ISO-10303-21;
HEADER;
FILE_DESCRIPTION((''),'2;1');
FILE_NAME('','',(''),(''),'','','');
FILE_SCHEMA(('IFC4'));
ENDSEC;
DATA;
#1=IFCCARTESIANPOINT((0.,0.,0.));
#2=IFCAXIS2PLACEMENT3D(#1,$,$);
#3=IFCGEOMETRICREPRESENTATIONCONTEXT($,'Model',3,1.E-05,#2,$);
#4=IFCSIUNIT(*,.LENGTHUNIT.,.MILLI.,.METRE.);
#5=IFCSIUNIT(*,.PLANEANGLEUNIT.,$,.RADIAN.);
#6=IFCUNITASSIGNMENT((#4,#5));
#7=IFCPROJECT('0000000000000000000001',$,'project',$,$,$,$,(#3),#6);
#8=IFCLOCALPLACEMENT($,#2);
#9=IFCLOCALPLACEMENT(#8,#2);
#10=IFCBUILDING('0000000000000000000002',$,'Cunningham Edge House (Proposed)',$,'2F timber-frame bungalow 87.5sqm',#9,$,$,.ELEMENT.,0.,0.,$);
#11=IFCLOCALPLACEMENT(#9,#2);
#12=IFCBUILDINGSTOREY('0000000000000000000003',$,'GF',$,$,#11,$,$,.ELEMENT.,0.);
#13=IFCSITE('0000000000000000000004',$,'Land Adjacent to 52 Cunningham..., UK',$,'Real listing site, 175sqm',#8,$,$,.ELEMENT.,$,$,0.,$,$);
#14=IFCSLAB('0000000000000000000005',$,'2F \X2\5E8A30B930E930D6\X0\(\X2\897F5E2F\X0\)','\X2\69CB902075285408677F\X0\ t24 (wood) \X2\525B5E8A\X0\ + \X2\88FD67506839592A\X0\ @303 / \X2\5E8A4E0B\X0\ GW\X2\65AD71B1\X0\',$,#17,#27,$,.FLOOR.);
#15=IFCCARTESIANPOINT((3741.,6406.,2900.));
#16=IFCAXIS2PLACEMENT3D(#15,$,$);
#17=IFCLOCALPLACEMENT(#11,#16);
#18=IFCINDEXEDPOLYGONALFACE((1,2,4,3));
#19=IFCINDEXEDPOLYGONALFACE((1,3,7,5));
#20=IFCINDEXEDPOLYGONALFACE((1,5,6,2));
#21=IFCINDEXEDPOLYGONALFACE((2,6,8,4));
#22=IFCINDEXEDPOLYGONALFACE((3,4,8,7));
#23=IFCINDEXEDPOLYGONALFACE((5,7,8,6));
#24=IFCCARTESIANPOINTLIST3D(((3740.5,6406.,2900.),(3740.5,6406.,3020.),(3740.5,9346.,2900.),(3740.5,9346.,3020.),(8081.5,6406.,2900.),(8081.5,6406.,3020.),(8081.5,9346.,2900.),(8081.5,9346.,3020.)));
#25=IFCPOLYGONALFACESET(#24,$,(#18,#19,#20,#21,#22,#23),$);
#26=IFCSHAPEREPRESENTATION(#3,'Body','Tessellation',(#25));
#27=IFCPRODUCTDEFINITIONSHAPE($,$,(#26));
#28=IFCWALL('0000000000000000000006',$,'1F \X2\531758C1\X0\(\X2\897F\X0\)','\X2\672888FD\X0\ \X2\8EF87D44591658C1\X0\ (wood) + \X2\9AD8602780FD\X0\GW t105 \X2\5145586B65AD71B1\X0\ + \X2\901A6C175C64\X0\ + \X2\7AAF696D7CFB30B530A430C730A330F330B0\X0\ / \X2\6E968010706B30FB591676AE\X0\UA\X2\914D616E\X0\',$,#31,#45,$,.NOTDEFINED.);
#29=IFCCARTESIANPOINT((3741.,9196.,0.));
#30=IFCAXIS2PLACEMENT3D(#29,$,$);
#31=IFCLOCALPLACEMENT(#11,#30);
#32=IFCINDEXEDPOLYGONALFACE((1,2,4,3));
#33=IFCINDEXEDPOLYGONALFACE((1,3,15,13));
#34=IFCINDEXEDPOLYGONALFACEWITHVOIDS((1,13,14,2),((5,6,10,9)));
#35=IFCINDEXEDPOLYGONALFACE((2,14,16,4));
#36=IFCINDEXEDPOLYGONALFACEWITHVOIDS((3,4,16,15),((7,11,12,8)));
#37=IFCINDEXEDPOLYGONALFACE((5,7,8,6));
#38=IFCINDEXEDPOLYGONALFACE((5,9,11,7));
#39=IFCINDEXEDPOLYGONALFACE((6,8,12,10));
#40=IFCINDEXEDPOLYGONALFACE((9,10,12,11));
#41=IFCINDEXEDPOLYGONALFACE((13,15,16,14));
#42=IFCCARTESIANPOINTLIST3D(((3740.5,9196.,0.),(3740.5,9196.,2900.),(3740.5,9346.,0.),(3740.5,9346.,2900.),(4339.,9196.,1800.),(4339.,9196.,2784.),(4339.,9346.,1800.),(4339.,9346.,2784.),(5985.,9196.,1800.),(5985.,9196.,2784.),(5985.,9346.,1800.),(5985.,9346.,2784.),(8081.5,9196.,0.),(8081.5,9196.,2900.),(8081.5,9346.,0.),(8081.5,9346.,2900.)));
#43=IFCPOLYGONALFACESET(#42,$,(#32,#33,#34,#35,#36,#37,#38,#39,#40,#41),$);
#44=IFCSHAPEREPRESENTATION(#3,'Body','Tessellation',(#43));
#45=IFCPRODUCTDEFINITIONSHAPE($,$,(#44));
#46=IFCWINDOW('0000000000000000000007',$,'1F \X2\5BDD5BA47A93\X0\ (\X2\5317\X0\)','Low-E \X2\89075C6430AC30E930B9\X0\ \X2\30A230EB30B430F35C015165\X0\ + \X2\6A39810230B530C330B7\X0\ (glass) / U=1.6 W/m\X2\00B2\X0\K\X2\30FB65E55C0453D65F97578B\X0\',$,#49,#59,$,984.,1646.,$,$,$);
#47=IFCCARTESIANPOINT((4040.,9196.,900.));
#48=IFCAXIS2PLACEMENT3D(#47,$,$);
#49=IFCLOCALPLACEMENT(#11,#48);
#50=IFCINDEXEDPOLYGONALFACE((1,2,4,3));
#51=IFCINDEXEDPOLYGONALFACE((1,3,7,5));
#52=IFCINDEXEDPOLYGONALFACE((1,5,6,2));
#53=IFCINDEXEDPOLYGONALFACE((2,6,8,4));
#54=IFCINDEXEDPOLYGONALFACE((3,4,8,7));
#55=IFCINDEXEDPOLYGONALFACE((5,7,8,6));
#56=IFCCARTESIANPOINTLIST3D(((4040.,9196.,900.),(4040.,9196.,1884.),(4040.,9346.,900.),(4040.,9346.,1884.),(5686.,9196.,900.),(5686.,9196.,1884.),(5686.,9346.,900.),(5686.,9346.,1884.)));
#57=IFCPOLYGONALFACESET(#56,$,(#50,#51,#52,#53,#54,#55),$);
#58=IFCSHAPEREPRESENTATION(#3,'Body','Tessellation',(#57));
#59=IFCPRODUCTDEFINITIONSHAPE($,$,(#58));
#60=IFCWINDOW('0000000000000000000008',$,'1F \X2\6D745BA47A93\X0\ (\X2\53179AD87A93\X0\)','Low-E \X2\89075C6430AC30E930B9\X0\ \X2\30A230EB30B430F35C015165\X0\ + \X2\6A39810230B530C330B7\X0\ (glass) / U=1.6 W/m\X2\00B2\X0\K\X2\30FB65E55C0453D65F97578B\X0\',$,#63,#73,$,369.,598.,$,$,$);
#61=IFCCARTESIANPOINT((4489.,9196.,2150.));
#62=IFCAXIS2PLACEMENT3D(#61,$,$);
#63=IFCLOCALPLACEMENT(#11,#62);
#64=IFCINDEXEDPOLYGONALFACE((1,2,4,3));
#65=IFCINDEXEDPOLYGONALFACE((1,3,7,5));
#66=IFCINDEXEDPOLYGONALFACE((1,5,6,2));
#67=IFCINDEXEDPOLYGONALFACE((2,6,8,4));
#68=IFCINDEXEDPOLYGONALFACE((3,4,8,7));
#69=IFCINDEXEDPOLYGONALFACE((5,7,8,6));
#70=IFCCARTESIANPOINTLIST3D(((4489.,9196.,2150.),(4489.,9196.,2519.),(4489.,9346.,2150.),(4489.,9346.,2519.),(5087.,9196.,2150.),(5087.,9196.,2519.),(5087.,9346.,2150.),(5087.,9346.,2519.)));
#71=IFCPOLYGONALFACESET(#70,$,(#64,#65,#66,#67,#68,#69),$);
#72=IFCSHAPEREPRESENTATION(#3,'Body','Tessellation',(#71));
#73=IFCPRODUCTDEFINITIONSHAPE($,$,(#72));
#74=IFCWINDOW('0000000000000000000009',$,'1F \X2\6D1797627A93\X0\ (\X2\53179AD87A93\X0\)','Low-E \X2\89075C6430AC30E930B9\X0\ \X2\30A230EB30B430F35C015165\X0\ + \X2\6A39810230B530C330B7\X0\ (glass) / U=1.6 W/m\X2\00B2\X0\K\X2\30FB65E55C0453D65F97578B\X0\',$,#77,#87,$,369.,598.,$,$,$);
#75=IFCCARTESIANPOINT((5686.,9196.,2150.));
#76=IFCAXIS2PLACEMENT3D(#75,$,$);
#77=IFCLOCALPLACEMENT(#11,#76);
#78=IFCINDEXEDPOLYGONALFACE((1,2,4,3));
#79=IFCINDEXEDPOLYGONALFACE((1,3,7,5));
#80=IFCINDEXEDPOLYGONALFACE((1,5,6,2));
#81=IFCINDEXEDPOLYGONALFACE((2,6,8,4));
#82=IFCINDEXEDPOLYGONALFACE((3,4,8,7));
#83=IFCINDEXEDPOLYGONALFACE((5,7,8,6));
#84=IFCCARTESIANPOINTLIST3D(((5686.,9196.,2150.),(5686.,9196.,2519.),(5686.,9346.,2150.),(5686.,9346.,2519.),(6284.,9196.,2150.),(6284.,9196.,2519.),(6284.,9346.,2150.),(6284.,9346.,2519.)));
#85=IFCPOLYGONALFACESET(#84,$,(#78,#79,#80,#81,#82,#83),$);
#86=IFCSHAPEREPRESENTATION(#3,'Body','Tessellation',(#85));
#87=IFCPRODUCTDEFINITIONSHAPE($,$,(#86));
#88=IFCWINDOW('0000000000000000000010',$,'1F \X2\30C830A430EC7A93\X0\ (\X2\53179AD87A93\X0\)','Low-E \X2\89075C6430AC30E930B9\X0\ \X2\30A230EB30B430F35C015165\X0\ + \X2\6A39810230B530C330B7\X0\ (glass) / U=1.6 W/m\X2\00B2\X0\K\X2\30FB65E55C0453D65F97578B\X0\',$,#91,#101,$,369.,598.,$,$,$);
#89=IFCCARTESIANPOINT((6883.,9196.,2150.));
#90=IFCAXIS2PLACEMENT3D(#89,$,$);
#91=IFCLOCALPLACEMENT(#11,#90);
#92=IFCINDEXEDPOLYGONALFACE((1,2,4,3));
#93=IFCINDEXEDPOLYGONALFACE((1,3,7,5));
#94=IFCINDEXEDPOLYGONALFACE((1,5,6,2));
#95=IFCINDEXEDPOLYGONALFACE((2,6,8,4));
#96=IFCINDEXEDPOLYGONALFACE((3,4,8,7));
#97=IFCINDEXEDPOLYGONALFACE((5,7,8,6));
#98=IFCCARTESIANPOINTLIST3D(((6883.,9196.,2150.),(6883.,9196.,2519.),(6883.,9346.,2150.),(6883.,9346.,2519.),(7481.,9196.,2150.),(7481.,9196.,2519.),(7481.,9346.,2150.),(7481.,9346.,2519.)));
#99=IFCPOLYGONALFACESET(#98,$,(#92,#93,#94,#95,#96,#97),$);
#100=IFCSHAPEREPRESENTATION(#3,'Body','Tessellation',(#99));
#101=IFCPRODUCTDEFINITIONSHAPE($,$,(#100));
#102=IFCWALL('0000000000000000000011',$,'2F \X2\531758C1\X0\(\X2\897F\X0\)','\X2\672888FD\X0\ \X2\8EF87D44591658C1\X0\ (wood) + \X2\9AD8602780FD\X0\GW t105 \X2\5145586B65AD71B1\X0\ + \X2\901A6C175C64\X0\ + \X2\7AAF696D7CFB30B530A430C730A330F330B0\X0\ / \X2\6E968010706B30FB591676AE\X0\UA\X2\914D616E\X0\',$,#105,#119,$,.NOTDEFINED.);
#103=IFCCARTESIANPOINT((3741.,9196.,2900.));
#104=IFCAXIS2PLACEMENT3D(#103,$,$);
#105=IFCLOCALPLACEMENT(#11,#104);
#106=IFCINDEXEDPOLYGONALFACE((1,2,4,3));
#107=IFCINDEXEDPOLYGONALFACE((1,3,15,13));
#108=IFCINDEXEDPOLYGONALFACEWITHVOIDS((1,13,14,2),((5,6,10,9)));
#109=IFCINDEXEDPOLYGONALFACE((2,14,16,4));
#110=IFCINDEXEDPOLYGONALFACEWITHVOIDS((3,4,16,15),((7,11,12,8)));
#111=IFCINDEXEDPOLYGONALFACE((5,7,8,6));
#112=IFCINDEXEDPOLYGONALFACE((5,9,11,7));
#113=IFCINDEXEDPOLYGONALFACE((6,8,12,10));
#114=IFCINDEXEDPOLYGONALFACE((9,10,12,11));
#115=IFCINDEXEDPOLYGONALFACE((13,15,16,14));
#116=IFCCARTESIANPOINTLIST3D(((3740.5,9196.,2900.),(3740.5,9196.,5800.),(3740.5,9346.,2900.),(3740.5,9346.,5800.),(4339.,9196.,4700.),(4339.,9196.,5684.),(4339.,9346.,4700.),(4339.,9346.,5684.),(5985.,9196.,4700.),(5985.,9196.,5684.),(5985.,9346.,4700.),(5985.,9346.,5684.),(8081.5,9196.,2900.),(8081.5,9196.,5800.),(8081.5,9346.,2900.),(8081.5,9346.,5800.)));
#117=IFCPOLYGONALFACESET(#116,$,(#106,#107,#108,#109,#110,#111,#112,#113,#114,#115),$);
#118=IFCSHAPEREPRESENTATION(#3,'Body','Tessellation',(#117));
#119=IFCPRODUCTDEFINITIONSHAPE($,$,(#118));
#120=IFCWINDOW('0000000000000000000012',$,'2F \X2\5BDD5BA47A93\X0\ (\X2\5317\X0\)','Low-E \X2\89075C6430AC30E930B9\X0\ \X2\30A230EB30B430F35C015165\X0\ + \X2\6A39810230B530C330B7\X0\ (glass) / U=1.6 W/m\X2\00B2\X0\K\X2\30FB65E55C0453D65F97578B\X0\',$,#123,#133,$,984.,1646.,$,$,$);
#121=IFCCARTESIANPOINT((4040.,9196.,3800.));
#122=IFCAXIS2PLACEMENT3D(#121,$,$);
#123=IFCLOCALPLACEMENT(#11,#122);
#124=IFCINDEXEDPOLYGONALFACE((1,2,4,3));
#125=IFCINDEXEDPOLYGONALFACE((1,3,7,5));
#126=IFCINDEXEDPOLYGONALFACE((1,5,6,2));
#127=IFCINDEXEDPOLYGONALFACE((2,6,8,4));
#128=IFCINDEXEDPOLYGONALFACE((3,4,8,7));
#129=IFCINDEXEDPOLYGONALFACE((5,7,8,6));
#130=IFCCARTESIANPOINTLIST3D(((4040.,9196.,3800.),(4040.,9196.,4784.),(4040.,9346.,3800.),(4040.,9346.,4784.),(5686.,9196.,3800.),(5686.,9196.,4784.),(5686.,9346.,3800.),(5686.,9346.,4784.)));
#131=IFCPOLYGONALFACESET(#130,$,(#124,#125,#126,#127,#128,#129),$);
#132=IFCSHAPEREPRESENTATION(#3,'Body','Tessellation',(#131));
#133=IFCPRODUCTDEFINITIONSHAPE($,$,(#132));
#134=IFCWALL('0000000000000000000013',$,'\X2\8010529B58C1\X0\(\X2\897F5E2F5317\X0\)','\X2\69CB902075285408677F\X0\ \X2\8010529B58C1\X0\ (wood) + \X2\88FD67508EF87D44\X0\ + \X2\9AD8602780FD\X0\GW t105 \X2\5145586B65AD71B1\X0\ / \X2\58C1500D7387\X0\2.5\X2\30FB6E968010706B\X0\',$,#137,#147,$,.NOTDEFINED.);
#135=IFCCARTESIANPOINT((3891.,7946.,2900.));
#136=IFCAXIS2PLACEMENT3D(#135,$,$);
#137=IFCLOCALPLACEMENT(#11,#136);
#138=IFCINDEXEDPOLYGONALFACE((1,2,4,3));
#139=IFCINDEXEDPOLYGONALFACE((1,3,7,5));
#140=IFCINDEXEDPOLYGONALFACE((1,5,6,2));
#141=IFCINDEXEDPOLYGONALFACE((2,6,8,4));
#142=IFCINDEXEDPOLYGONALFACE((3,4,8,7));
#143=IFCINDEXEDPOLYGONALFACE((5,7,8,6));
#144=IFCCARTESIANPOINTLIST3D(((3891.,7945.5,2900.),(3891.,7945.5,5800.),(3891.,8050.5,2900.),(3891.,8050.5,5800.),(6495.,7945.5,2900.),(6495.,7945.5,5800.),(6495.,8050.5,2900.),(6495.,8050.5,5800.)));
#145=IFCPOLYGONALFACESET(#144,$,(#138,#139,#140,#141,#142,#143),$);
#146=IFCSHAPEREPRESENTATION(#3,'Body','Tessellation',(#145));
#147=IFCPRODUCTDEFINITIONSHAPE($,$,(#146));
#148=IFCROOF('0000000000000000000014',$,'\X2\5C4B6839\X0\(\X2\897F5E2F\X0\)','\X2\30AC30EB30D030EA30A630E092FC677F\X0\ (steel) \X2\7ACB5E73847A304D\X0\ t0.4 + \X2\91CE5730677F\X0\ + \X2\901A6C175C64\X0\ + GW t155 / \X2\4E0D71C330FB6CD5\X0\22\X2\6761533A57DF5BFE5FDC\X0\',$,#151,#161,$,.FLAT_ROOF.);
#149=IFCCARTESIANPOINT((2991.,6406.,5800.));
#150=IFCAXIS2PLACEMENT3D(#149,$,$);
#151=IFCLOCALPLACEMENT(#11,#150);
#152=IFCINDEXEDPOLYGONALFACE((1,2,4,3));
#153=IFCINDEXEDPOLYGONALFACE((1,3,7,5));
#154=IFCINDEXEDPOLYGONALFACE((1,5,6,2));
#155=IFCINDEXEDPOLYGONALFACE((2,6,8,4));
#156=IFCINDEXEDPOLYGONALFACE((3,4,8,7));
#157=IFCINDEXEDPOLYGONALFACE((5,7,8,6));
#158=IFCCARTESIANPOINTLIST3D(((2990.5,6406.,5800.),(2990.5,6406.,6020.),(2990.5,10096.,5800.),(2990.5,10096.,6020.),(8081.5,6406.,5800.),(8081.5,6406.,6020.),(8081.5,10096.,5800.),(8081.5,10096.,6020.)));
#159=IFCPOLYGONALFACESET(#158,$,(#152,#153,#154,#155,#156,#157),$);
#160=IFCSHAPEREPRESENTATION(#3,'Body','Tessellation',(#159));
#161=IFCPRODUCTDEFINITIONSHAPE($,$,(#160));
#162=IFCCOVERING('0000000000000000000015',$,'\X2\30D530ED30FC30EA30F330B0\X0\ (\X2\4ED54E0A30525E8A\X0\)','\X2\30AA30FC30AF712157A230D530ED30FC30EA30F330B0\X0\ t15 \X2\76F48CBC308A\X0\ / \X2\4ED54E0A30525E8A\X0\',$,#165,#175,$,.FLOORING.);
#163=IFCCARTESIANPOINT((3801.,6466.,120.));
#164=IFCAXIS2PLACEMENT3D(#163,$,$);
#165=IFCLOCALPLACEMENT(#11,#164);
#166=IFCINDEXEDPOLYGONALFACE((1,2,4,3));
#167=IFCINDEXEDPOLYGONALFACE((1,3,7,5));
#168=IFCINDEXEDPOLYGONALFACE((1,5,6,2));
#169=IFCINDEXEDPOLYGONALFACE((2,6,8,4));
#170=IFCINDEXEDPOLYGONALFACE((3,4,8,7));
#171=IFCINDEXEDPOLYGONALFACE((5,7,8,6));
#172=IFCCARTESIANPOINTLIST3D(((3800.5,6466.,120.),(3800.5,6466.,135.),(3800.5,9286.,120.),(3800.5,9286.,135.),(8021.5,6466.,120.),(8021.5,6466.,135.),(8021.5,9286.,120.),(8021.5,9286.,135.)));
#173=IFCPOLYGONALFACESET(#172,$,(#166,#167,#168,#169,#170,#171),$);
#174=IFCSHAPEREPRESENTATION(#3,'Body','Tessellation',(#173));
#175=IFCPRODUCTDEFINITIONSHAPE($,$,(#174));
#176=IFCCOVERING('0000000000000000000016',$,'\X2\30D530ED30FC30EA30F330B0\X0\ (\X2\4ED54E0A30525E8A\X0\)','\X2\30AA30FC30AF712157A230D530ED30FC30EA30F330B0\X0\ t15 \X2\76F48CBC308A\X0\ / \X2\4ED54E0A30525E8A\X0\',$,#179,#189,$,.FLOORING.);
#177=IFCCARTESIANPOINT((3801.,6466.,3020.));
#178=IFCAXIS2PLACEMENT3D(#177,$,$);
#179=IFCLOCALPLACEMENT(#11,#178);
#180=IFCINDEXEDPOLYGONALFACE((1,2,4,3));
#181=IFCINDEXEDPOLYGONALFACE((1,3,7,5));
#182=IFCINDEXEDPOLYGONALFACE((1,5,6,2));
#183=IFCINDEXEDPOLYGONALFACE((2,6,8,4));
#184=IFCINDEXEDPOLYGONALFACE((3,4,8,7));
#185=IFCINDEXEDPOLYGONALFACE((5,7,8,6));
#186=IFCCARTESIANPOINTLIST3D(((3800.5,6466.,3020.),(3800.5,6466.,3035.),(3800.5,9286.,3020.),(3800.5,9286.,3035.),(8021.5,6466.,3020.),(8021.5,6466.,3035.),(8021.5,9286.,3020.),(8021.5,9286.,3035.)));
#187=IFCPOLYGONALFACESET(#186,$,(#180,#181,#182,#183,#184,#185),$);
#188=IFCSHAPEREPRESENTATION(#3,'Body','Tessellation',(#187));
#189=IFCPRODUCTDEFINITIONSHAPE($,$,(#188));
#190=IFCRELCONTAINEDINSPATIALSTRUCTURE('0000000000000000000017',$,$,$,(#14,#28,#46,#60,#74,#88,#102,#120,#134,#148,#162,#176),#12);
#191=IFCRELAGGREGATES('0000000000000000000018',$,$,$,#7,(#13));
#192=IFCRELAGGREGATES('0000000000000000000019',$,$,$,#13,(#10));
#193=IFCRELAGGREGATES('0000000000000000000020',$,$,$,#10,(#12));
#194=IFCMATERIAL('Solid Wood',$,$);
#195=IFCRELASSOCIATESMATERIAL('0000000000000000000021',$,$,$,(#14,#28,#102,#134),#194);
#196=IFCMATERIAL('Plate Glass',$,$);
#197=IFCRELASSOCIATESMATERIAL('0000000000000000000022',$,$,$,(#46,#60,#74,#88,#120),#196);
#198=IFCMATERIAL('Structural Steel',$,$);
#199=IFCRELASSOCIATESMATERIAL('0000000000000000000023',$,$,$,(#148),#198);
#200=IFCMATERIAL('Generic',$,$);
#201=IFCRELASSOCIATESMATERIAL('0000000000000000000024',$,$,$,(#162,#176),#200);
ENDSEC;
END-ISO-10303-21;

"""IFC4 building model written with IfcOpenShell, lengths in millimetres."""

from ifc_helpers import new_model, si_unit, frame, frame_2d, origin, place, context, project, spatial, rectangle, extrude, material, element, fill, save


model = new_model("IFC4")

# Units and contexts
model_context = context("Model", 3, precision=1e-05, world=origin())
ifc_project = project(units=[si_unit("LENGTHUNIT", "METRE", prefix="MILLI"), si_unit("PLANEANGLEUNIT", "RADIAN")], contexts=[model_context])

# Site, building, storey
site_placement = place(None, origin())
site = spatial("IfcSite", under=ifc_project, at=site_placement, Name="Land Adjacent to 52 Cunningham..., UK", ObjectType="Real listing site, 175sqm", CompositionType="ELEMENT", RefElevation=0.0)
building_placement = place(site_placement, origin())
building = spatial("IfcBuilding", under=site, at=building_placement, Name="Cunningham Edge House (Proposed)", ObjectType="2F timber-frame bungalow 87.5sqm", CompositionType="ELEMENT", ElevationOfRefHeight=0.0, ElevationOfTerrain=0.0)
storey_placement = place(building_placement, origin())
storey = spatial("IfcBuildingStorey", under=building, at=storey_placement, Name="GF", CompositionType="ELEMENT", Elevation=0.0)

# Slab
ifc_material_1 = material(Name="Solid Wood")
slab_1_placement = place(storey_placement, frame((3741.0, 6406.0, 2900.0)))
element("IfcSlab", 1, at=slab_1_placement, inside=storey, material=ifc_material_1, Name="2F 床スラブ(西帯)", Description="構造用合板 t24 (wood) 剛床 + 製材根太 @303 / 床下 GW断熱", PredefinedType="FLOOR", context=model_context, shape_type="SweptSolid", body=[
    extrude(rectangle(XDim=4341.0, YDim=2940.0, at=frame_2d((2170.0, 1470.0))), frame((3741.0, 6406.0, 2900.0)), (0.0, 0.0, 1.0), 120.0),
])

# Wall, openings, windows
wall_1_placement = place(storey_placement, frame((3741.0, 9196.0, 0.0)))
wall_1 = element("IfcWall", 2, at=wall_1_placement, inside=storey, material=ifc_material_1, Name="1F 北壁(西)", Description="木製 軸組外壁 (wood) + 高性能GW t105 充填断熱 + 通気層 + 窯業系サイディング / 準耐火・外皮UA配慮", PredefinedType="NOTDEFINED", context=model_context, shape_type="SweptSolid", body=[
    extrude(rectangle(XDim=4341.0, YDim=150.0, at=frame_2d((2170.0, 75.0))), frame((3741.0, 9196.0, 0.0)), (0.0, 0.0, 1.0), 2900.0),
])
opening_1_placement = place(storey_placement, frame((4040.0, 9196.0, 900.0)))
opening_1 = element("IfcOpeningElement", 3, at=opening_1_placement, cuts=wall_1, PredefinedType="NOTDEFINED", context=model_context, shape_type="SweptSolid", body=[
    extrude(rectangle(XDim=1646.0, YDim=150.0, at=frame_2d((823.0, 75.0))), frame((4040.0, 9196.0, 900.0)), (0.0, 0.0, 1.0), 984.0),
])
opening_2_placement = place(storey_placement, frame((4489.0, 9196.0, 2150.0)))
opening_2 = element("IfcOpeningElement", 4, at=opening_2_placement, cuts=wall_1, PredefinedType="NOTDEFINED", context=model_context, shape_type="SweptSolid", body=[
    extrude(rectangle(XDim=598.0, YDim=150.0, at=frame_2d((299.0, 75.0))), frame((4489.0, 9196.0, 2150.0)), (0.0, 0.0, 1.0), 369.0),
])
opening_3_placement = place(storey_placement, frame((5686.0, 9196.0, 2150.0)))
opening_3 = element("IfcOpeningElement", 5, at=opening_3_placement, cuts=wall_1, PredefinedType="NOTDEFINED", context=model_context, shape_type="SweptSolid", body=[
    extrude(rectangle(XDim=598.0, YDim=150.0, at=frame_2d((299.0, 75.0))), frame((5686.0, 9196.0, 2150.0)), (0.0, 0.0, 1.0), 369.0),
])
opening_4_placement = place(storey_placement, frame((6883.0, 9196.0, 2150.0)))
opening_4 = element("IfcOpeningElement", 6, at=opening_4_placement, cuts=wall_1, PredefinedType="NOTDEFINED", context=model_context, shape_type="SweptSolid", body=[
    extrude(rectangle(XDim=598.0, YDim=150.0, at=frame_2d((299.0, 75.0))), frame((6883.0, 9196.0, 2150.0)), (0.0, 0.0, 1.0), 369.0),
])
ifc_material_2 = material(Name="Plate Glass")
window_1_placement = place(storey_placement, frame((4040.0, 9196.0, 900.0)))
window_1 = element("IfcWindow", 7, at=window_1_placement, inside=storey, material=ifc_material_2, Name="1F 寝室窓 (北)", Description="Low-E 複層ガラス アルゴン封入 + 樹脂サッシ (glass) / U=1.6 W/m²K・日射取得型", OverallHeight=984.0, OverallWidth=1646.0, context=model_context, shape_type="SweptSolid", body=[
    extrude(rectangle(XDim=1646.0, YDim=150.0, at=frame_2d((823.0, 75.0))), frame((4040.0, 9196.0, 900.0)), (0.0, 0.0, 1.0), 984.0),
])
fill(opening_1, window_1)
window_2_placement = place(storey_placement, frame((4489.0, 9196.0, 2150.0)))
window_2 = element("IfcWindow", 8, at=window_2_placement, inside=storey, material=ifc_material_2, Name="1F 浴室窓 (北高窓)", Description="Low-E 複層ガラス アルゴン封入 + 樹脂サッシ (glass) / U=1.6 W/m²K・日射取得型", OverallHeight=369.0, OverallWidth=598.0, context=model_context, shape_type="SweptSolid", body=[
    extrude(rectangle(XDim=598.0, YDim=150.0, at=frame_2d((299.0, 75.0))), frame((4489.0, 9196.0, 2150.0)), (0.0, 0.0, 1.0), 369.0),
])
fill(opening_2, window_2)
window_3_placement = place(storey_placement, frame((5686.0, 9196.0, 2150.0)))
window_3 = element("IfcWindow", 9, at=window_3_placement, inside=storey, material=ifc_material_2, Name="1F 洗面窓 (北高窓)", Description="Low-E 複層ガラス アルゴン封入 + 樹脂サッシ (glass) / U=1.6 W/m²K・日射取得型", OverallHeight=369.0, OverallWidth=598.0, context=model_context, shape_type="SweptSolid", body=[
    extrude(rectangle(XDim=598.0, YDim=150.0, at=frame_2d((299.0, 75.0))), frame((5686.0, 9196.0, 2150.0)), (0.0, 0.0, 1.0), 369.0),
])
fill(opening_3, window_3)
window_4_placement = place(storey_placement, frame((6883.0, 9196.0, 2150.0)))
window_4 = element("IfcWindow", 10, at=window_4_placement, inside=storey, material=ifc_material_2, Name="1F トイレ窓 (北高窓)", Description="Low-E 複層ガラス アルゴン封入 + 樹脂サッシ (glass) / U=1.6 W/m²K・日射取得型", OverallHeight=369.0, OverallWidth=598.0, context=model_context, shape_type="SweptSolid", body=[
    extrude(rectangle(XDim=598.0, YDim=150.0, at=frame_2d((299.0, 75.0))), frame((6883.0, 9196.0, 2150.0)), (0.0, 0.0, 1.0), 369.0),
])
fill(opening_4, window_4)

# Wall, opening, window
wall_2_placement = place(storey_placement, frame((3741.0, 9196.0, 2900.0)))
wall_2 = element("IfcWall", 11, at=wall_2_placement, inside=storey, material=ifc_material_1, Name="2F 北壁(西)", Description="木製 軸組外壁 (wood) + 高性能GW t105 充填断熱 + 通気層 + 窯業系サイディング / 準耐火・外皮UA配慮", PredefinedType="NOTDEFINED", context=model_context, shape_type="SweptSolid", body=[
    extrude(rectangle(XDim=4341.0, YDim=150.0, at=frame_2d((2170.0, 75.0))), frame((3741.0, 9196.0, 2900.0)), (0.0, 0.0, 1.0), 2900.0),
])
opening_5_placement = place(storey_placement, frame((4040.0, 9196.0, 3800.0)))
opening_5 = element("IfcOpeningElement", 12, at=opening_5_placement, cuts=wall_2, PredefinedType="NOTDEFINED", context=model_context, shape_type="SweptSolid", body=[
    extrude(rectangle(XDim=1646.0, YDim=150.0, at=frame_2d((823.0, 75.0))), frame((4040.0, 9196.0, 3800.0)), (0.0, 0.0, 1.0), 984.0),
])
window_5_placement = place(storey_placement, frame((4040.0, 9196.0, 3800.0)))
window_5 = element("IfcWindow", 13, at=window_5_placement, inside=storey, material=ifc_material_2, Name="2F 寝室窓 (北)", Description="Low-E 複層ガラス アルゴン封入 + 樹脂サッシ (glass) / U=1.6 W/m²K・日射取得型", OverallHeight=984.0, OverallWidth=1646.0, context=model_context, shape_type="SweptSolid", body=[
    extrude(rectangle(XDim=1646.0, YDim=150.0, at=frame_2d((823.0, 75.0))), frame((4040.0, 9196.0, 3800.0)), (0.0, 0.0, 1.0), 984.0),
])
fill(opening_5, window_5)

# Wall
wall_3_placement = place(storey_placement, frame((3891.0, 7946.0, 2900.0)))
element("IfcWall", 14, at=wall_3_placement, inside=storey, material=ifc_material_1, Name="耐力壁(西帯北)", Description="構造用合板 耐力壁 (wood) + 製材軸組 + 高性能GW t105 充填断熱 / 壁倍率2.5・準耐火", PredefinedType="NOTDEFINED", context=model_context, shape_type="SweptSolid", body=[
    extrude(rectangle(XDim=2604.0, YDim=105.0, at=frame_2d((1302.0, 52.0))), frame((3891.0, 7946.0, 2900.0)), (0.0, 0.0, 1.0), 2900.0),
])

# Roof
ifc_material_3 = material(Name="Structural Steel")
for number, where, name in (
    (15, (2991.0, 6406.0, 5800.0), "屋根(西帯)"),
):
    element("IfcRoof", number, at=place(storey_placement, frame(where)), inside=storey, material=ifc_material_3, Name=name, Description="ガルバリウム鋼板 (steel) 立平葺き t0.4 + 野地板 + 通気層 + GW t155 / 不燃・法22条区域対応", PredefinedType="FLAT_ROOF", context=model_context, shape_type="SweptSolid", body=[
        extrude(rectangle(XDim=5091.0, YDim=3690.0, at=frame_2d((2545.0, 1845.0))), frame((2991.0, 6406.0, 5800.0)), (0.0, 0.0, 1.0), 220.0),
    ])

# Coverings
ifc_material_4 = material(Name="Generic")
covering_1_placement = place(storey_placement, frame((3801.0, 6466.0, 120.0)))
element("IfcCovering", 16, at=covering_1_placement, inside=storey, material=ifc_material_4, Name="フローリング (仕上げ床)", Description="オーク無垢フローリング t15 直貼り / 仕上げ床", PredefinedType="FLOORING", context=model_context, shape_type="SweptSolid", body=[
    extrude(rectangle(XDim=4221.0, YDim=2820.0, at=frame_2d((2110.0, 1410.0))), frame((3801.0, 6466.0, 120.0)), (0.0, 0.0, 1.0), 15.0),
])
covering_2_placement = place(storey_placement, frame((3801.0, 6466.0, 3020.0)))
element("IfcCovering", 17, at=covering_2_placement, inside=storey, material=ifc_material_4, Name="フローリング (仕上げ床)", Description="オーク無垢フローリング t15 直貼り / 仕上げ床", PredefinedType="FLOORING", context=model_context, shape_type="SweptSolid", body=[
    extrude(rectangle(XDim=4221.0, YDim=2820.0, at=frame_2d((2110.0, 1410.0))), frame((3801.0, 6466.0, 3020.0)), (0.0, 0.0, 1.0), 15.0),
])

save(model, "model.ifc")
